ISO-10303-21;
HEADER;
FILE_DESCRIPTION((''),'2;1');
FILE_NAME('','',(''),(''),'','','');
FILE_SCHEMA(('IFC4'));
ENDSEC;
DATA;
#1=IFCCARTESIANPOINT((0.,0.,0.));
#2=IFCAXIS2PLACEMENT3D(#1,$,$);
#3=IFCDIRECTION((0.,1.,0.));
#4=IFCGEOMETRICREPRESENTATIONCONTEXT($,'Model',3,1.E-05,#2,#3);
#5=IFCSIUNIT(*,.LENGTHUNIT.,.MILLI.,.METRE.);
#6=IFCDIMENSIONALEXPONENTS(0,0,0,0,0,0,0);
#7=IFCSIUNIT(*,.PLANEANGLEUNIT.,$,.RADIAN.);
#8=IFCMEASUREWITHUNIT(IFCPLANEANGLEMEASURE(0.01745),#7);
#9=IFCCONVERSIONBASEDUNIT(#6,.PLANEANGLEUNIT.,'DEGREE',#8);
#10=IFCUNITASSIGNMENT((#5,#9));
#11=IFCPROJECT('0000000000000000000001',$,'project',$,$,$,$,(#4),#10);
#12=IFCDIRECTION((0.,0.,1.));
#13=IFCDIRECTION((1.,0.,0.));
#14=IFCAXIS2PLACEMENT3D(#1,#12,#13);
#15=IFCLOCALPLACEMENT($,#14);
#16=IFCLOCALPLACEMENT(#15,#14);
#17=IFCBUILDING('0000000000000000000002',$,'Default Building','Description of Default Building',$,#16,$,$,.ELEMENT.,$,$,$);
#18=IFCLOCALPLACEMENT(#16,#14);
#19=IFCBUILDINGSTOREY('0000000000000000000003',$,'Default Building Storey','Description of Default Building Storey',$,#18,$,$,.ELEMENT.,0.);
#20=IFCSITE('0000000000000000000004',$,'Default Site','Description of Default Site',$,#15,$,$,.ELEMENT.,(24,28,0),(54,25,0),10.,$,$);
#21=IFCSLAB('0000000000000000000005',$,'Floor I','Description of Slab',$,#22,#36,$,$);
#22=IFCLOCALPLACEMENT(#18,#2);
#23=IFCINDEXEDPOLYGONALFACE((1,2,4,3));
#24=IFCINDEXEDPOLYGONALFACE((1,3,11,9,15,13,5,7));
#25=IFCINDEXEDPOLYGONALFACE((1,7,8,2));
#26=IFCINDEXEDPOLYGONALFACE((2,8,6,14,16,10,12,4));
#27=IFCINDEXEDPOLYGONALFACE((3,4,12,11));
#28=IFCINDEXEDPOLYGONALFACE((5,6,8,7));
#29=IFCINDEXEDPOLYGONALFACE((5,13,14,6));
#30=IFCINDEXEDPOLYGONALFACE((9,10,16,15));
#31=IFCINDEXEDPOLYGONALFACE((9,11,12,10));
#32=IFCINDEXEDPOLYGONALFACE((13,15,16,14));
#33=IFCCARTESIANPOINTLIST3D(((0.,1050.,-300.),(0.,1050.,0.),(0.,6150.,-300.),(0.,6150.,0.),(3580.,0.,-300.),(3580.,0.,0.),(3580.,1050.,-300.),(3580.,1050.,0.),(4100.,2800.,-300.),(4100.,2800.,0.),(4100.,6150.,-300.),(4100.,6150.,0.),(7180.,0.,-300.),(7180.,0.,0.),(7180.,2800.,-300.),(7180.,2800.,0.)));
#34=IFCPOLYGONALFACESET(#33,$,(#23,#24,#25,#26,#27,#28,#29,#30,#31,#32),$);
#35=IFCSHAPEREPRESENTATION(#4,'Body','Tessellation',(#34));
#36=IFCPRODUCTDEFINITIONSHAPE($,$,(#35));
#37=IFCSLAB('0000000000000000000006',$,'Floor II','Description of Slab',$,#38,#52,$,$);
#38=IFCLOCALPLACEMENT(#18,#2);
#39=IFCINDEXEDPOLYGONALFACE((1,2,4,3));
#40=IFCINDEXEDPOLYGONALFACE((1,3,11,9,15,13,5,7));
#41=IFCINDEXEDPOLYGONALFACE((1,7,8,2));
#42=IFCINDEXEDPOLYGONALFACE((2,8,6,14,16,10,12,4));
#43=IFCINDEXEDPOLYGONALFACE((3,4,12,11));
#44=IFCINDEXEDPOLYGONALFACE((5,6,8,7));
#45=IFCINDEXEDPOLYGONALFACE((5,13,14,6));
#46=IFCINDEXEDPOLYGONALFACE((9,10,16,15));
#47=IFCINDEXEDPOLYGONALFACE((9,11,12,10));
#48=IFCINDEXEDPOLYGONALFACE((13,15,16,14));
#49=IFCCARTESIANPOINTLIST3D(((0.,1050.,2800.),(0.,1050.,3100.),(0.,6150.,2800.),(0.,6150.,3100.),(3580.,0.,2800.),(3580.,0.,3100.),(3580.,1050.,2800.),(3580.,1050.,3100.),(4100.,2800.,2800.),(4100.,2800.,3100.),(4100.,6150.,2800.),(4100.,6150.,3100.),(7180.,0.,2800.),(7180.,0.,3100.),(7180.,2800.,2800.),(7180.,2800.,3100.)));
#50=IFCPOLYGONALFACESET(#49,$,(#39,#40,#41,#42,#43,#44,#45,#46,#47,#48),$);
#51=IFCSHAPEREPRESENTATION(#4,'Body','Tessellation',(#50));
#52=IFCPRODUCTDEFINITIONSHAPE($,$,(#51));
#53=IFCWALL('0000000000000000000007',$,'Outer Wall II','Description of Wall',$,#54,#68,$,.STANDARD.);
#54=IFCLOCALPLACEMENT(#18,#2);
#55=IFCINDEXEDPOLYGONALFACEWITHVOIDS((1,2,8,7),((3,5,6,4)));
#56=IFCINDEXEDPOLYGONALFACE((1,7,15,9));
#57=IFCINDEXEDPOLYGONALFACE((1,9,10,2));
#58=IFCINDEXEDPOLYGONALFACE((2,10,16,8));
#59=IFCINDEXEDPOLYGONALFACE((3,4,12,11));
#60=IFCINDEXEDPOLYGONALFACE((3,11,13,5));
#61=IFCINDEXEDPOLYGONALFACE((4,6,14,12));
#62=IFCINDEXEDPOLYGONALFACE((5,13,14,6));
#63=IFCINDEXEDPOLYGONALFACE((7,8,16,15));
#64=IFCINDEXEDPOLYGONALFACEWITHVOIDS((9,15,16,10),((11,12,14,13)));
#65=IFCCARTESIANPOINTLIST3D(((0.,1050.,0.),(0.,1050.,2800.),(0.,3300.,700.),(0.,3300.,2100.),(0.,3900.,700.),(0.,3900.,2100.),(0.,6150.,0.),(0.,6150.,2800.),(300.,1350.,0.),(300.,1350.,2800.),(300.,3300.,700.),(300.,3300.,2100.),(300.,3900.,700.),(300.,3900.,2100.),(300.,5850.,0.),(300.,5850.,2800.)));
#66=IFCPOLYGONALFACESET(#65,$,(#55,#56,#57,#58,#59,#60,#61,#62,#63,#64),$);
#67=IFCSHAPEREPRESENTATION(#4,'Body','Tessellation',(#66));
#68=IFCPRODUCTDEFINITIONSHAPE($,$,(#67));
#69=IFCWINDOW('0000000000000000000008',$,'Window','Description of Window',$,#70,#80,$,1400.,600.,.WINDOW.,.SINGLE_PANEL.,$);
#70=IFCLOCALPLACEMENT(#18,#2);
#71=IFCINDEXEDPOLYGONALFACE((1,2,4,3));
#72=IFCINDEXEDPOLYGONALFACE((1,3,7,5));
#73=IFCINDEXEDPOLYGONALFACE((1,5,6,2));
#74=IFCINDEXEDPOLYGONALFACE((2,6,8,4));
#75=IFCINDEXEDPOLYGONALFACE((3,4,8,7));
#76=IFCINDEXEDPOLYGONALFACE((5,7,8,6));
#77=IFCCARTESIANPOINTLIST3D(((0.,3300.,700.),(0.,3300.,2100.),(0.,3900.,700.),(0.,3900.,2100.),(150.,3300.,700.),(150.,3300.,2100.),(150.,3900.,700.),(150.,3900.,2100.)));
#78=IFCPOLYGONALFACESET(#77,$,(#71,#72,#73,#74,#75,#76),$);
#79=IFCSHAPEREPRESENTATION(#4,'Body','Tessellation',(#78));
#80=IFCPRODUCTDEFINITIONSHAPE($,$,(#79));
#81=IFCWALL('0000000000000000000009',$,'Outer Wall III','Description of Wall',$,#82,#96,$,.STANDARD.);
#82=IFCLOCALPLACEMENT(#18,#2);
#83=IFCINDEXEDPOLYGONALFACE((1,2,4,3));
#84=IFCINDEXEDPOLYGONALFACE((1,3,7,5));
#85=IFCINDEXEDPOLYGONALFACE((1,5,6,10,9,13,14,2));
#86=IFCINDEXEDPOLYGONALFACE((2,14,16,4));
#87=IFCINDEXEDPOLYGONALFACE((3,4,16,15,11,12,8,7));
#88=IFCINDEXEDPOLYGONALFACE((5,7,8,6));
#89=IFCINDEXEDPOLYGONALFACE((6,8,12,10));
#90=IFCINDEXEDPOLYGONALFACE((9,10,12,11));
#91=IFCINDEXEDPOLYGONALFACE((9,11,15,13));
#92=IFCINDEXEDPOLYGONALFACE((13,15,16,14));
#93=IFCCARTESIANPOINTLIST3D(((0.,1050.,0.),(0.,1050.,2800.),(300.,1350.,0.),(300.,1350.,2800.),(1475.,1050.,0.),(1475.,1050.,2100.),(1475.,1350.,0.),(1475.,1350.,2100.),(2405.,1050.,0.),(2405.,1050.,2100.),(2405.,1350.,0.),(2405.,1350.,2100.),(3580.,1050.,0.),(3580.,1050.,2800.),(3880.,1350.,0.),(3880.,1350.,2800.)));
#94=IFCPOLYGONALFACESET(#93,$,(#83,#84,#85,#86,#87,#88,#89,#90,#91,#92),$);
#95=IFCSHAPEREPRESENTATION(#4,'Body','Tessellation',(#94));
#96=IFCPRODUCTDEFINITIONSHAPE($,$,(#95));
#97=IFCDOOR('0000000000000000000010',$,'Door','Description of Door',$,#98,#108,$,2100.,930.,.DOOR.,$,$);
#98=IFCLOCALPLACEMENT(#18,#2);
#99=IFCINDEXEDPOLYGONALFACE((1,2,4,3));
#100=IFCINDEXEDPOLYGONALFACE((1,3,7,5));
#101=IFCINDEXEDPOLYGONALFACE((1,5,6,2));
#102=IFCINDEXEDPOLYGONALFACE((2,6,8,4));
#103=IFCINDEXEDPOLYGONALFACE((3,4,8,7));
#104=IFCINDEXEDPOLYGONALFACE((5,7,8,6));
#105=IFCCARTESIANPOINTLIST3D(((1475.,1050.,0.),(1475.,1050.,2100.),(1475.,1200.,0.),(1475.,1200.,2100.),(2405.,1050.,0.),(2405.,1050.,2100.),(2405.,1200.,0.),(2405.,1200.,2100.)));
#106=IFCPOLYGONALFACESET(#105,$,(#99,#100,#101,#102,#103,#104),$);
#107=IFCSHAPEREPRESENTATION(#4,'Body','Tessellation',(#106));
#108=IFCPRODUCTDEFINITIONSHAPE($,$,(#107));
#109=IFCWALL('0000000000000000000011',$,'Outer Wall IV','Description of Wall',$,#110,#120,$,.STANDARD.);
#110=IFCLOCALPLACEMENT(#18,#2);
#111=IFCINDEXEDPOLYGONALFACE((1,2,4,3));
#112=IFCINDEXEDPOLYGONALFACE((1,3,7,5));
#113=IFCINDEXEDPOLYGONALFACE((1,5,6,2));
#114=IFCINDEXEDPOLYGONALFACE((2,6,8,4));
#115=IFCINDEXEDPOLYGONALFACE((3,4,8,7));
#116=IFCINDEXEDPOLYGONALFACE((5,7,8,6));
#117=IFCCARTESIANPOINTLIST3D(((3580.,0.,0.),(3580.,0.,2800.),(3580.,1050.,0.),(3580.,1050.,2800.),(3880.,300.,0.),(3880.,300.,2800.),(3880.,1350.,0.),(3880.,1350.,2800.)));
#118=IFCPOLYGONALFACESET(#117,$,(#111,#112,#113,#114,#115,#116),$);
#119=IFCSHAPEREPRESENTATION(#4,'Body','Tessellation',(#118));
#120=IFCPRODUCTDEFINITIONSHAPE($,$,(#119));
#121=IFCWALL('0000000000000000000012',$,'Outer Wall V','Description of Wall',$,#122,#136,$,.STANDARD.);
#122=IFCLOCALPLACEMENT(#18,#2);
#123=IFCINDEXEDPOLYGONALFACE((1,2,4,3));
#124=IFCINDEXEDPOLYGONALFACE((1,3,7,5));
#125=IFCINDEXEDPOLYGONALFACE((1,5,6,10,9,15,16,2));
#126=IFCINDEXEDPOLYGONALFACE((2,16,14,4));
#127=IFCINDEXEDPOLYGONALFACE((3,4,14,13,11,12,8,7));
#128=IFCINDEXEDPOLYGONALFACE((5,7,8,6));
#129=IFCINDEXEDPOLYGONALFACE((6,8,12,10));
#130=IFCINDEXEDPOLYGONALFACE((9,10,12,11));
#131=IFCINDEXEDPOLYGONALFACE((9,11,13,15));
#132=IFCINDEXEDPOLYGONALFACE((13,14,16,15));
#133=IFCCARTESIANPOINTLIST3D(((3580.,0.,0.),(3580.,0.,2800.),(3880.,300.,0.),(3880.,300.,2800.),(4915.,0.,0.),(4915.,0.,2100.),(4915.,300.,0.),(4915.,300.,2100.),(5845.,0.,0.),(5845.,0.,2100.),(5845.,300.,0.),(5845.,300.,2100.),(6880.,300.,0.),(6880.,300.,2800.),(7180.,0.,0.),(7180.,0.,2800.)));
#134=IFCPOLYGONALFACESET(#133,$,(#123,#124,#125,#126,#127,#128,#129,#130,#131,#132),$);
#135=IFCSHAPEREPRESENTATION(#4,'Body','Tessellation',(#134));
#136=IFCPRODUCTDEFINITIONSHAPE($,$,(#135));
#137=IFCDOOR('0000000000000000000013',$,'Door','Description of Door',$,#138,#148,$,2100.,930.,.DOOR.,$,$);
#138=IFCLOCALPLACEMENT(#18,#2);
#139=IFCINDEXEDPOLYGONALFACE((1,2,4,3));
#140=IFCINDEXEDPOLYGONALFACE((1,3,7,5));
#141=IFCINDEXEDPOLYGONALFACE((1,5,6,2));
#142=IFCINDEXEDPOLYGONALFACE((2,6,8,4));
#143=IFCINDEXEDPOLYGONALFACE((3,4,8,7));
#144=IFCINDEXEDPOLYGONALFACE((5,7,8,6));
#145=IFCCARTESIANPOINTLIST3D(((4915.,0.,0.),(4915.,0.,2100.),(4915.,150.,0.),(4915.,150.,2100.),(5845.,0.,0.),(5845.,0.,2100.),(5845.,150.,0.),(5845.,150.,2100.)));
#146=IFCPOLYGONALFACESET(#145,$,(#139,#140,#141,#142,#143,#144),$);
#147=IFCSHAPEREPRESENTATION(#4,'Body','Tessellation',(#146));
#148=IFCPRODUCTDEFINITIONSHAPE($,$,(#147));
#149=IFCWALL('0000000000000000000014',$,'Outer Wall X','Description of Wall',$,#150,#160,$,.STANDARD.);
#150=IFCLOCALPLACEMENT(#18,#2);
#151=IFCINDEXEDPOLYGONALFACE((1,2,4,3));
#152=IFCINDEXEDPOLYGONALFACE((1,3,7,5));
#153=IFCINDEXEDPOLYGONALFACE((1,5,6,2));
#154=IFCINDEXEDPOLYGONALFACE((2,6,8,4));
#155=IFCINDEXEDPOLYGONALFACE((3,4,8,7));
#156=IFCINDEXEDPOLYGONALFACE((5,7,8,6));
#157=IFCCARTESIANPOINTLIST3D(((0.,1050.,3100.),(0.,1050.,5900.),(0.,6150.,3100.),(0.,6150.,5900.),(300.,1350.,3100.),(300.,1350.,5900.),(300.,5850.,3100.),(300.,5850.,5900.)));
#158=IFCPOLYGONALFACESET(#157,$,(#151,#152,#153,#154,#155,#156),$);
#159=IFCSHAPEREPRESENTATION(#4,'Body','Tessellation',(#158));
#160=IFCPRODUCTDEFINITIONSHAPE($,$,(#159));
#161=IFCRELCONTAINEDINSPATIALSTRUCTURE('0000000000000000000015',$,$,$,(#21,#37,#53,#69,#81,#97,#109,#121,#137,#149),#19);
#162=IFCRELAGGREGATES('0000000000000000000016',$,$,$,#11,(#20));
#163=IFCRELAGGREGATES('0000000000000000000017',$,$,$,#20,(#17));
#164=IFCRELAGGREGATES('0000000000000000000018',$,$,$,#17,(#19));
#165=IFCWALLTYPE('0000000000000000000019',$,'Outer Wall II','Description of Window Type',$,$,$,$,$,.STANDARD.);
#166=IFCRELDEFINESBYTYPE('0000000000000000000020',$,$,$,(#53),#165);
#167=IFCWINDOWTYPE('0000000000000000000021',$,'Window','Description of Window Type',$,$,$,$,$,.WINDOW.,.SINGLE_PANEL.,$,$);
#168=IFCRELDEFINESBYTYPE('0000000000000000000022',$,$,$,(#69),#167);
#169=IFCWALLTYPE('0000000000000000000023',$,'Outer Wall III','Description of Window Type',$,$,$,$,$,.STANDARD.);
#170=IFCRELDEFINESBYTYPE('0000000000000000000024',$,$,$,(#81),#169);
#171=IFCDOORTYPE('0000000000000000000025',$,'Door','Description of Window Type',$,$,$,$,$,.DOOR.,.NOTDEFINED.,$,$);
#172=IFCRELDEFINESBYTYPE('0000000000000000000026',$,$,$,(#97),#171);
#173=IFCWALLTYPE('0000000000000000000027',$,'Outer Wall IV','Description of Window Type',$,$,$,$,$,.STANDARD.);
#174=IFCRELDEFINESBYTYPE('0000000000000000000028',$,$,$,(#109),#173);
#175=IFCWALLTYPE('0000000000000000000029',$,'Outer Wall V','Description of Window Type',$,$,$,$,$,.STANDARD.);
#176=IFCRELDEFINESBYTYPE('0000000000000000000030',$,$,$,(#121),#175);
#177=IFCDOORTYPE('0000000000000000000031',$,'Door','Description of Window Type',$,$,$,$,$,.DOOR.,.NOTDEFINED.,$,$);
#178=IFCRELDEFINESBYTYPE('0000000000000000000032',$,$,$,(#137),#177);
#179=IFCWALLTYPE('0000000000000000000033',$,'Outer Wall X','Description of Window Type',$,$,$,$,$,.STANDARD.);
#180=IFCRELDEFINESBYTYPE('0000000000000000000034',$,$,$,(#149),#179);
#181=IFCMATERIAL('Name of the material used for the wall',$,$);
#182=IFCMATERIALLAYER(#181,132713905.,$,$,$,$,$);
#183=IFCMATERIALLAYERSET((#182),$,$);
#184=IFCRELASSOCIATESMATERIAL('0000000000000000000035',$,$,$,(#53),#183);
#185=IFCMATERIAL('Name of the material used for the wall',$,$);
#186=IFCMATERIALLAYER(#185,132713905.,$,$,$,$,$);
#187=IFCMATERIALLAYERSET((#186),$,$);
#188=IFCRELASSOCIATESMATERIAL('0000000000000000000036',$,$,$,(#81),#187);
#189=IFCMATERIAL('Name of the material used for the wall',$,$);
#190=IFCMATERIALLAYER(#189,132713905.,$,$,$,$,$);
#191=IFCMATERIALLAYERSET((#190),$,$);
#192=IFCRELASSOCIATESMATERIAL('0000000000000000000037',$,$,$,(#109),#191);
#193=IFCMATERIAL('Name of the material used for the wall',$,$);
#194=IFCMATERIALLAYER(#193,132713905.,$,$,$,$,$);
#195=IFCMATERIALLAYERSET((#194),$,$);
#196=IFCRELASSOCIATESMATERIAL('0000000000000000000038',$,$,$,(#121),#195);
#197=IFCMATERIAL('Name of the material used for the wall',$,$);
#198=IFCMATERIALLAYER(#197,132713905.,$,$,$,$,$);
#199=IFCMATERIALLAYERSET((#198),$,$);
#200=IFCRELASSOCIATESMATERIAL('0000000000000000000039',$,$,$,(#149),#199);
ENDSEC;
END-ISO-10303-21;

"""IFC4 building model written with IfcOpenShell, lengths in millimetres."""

from ifc_helpers import new_model, entity, si_unit, converted_unit, direction, frame, origin, origin_with_axes, place, context, project, spatial, polyline, outline, extrude, material, layer, layer_set, layer_usage, type_object, element, fill, save


model = new_model("IFC4")

# Units and contexts
model_context = context("Model", 3, precision=1e-05, world=origin(), true_north=direction((0.0, 1.0, 0.0)))
ifc_project = project(units=[si_unit("LENGTHUNIT", "METRE", prefix="MILLI"), converted_unit("PLANEANGLEUNIT", "DEGREE", entity("IfcPlaneAngleMeasure", 0.01745), si_unit("PLANEANGLEUNIT", "RADIAN"), dimensions=[0, 0, 0, 0, 0, 0, 0])], contexts=[model_context])

# Site, building, storey
site_placement = place(None, origin_with_axes())
site = spatial("IfcSite", under=ifc_project, at=site_placement, Name="Default Site", Description="Description of Default Site", CompositionType="ELEMENT", RefLatitude=(24, 28, 0), RefLongitude=(54, 25, 0), RefElevation=10.0)
building_placement = place(site_placement, origin_with_axes())
building = spatial("IfcBuilding", under=site, at=building_placement, Name="Default Building", Description="Description of Default Building", CompositionType="ELEMENT")
storey_placement = place(building_placement, origin_with_axes())
storey = spatial("IfcBuildingStorey", under=building, at=storey_placement, Name="Default Building Storey", Description="Description of Default Building Storey", CompositionType="ELEMENT", Elevation=0.0)

# Slabs
for number, where, z_axis, x_axis, name in (
    (1, (0.0, 0.0, -300.0), (0.0, 0.0, 1.0), (1.0, 0.0, 0.0), "Floor I"),
    (2, (0.0, 0.0, 2800.0), (0.0, 0.0, 1.0), (1.0, 0.0, 0.0), "Floor II"),
):
    element("IfcSlab", number, at=place(storey_placement, frame(where, z_axis=z_axis, x_axis=x_axis)), inside=storey, Name=name, Description="Description of Slab", context=model_context, shape_type="SweptSolid", body=[
        extrude(outline(polyline([(0.0, 1050.0), (0.0, 6150.0), (4100.0, 6150.0), (4100.0, 2800.0), (7180.0, 2800.0), (7180.0, 0.0), (3580.0, 0.0), (3580.0, 1050.0), (0.0, 1050.0)])), origin_with_axes(), (0.0, 0.0, 1.0), 300.0),
    ])

# Wall, opening, window
ifc_material_1 = material(Name="Name of the material used for the wall")
ifc_layer_1 = layer(ifc_material_1, 132713905.0)
ifc_layer_set_1 = layer_set([ifc_layer_1])
ifc_layer_usage_1 = layer_usage(ifc_layer_set_1, "AXIS2", "POSITIVE", -66356952.5)
wall_type_1 = type_object("IfcWallType", Name="Outer Wall II", Description="Description of Window Type", PredefinedType="STANDARD")
wall_1_placement = place(storey_placement, frame((150.0, 6000.0, 0.0), z_axis=(0.0, 0.0, 1.0), x_axis=(0.0, -1.0, 0.0)))
wall_1 = element("IfcWall", 3, at=wall_1_placement, inside=storey, type_object=wall_type_1, material=ifc_layer_usage_1, Name="Outer Wall II", Description="Description of Wall", PredefinedType="STANDARD", context=model_context, shape_type="SweptSolid", body=[
    extrude(outline(polyline([(-150.0, -150.0), (150.0, 150.0), (4650.0, 150.0), (4950.0, -150.0), (-150.0, -150.0)])), origin_with_axes(), (0.0, 0.0, 1.0), 2800.0),
])
opening_1_placement = place(wall_1_placement, frame((2100.0, -150.0, 700.0), z_axis=(0.0, 0.0, 1.0), x_axis=(1.0, 0.0, 0.0)))
opening_1 = element("IfcOpeningElement", 4, at=opening_1_placement, cuts=wall_1, context=model_context, shape_type="SweptSolid", body=[
    extrude(outline(polyline([(0.0, 0.0), (0.0, 300.0), (600.0, 300.0), (600.0, 0.0), (0.0, 0.0)])), origin_with_axes(), (0.0, 0.0, 1.0), 1400.0),
])
window_type_1 = type_object("IfcWindowType", Name="Window", Description="Description of Window Type", PartitioningType="SINGLE_PANEL", PredefinedType="WINDOW")
window_1_placement = place(opening_1_placement, origin_with_axes())
window_1 = element("IfcWindow", 5, at=window_1_placement, inside=storey, type_object=window_type_1, Name="Window", Description="Description of Window", OverallHeight=1400.0, OverallWidth=600.0, PartitioningType="SINGLE_PANEL", PredefinedType="WINDOW", context=model_context, shape_type="SweptSolid", body=[
    extrude(outline(polyline([(0.0, 0.0), (0.0, 150.0), (600.0, 150.0), (600.0, 0.0), (0.0, 0.0)])), origin_with_axes(), (0.0, 0.0, 1.0), 1400.0),
])
fill(opening_1, window_1)

# Wall, opening, door
ifc_material_2 = material(Name="Name of the material used for the wall")
ifc_layer_2 = layer(ifc_material_2, 132713905.0)
ifc_layer_set_2 = layer_set([ifc_layer_2])
ifc_layer_usage_2 = layer_usage(ifc_layer_set_2, "AXIS2", "POSITIVE", -66356952.5)
wall_type_2 = type_object("IfcWallType", Name="Outer Wall III", Description="Description of Window Type", PredefinedType="STANDARD")
wall_2_placement = place(storey_placement, frame((150.0, 1200.0, 0.0), z_axis=(0.0, 0.0, 1.0), x_axis=(1.0, 0.0, 0.0)))
wall_2 = element("IfcWall", 6, at=wall_2_placement, inside=storey, type_object=wall_type_2, material=ifc_layer_usage_2, Name="Outer Wall III", Description="Description of Wall", PredefinedType="STANDARD", context=model_context, shape_type="SweptSolid", body=[
    extrude(outline(polyline([(-150.0, -150.0), (150.0, 150.0), (3730.0, 150.0), (3430.0, -150.0), (-150.0, -150.0)])), origin_with_axes(), (0.0, 0.0, 1.0), 2800.0),
])
opening_2_placement = place(wall_2_placement, frame((1325.0, -150.0, 0.0), z_axis=(0.0, 0.0, 1.0), x_axis=(1.0, 0.0, 0.0)))
opening_2 = element("IfcOpeningElement", 7, at=opening_2_placement, cuts=wall_2, context=model_context, shape_type="SweptSolid", body=[
    extrude(outline(polyline([(0.0, 0.0), (0.0, 300.0), (930.0, 300.0), (930.0, 0.0), (0.0, 0.0)])), origin_with_axes(), (0.0, 0.0, 1.0), 2100.0),
])
door_type_1 = type_object("IfcDoorType", Name="Door", Description="Description of Window Type", PredefinedType="DOOR")
door_1_placement = place(opening_2_placement, origin_with_axes())
door_1 = element("IfcDoor", 8, at=door_1_placement, inside=storey, type_object=door_type_1, Name="Door", Description="Description of Door", OverallHeight=2100.0, OverallWidth=930.0, PredefinedType="DOOR", context=model_context, shape_type="SweptSolid", body=[
    extrude(outline(polyline([(0.0, 0.0), (0.0, 150.0), (930.0, 150.0), (930.0, 0.0), (0.0, 0.0)])), origin_with_axes(), (0.0, 0.0, 1.0), 2100.0),
])
fill(opening_2, door_1)

# Wall
ifc_material_3 = material(Name="Name of the material used for the wall")
ifc_layer_3 = layer(ifc_material_3, 132713905.0)
ifc_layer_set_3 = layer_set([ifc_layer_3])
ifc_layer_usage_3 = layer_usage(ifc_layer_set_3, "AXIS2", "POSITIVE", -66356952.5)
wall_type_3 = type_object("IfcWallType", Name="Outer Wall IV", Description="Description of Window Type", PredefinedType="STANDARD")
wall_3_placement = place(storey_placement, frame((3730.0, 1200.0, 0.0), z_axis=(0.0, 0.0, 1.0), x_axis=(0.0, -1.0, 0.0)))
element("IfcWall", 9, at=wall_3_placement, inside=storey, type_object=wall_type_3, material=ifc_layer_usage_3, Name="Outer Wall IV", Description="Description of Wall", PredefinedType="STANDARD", context=model_context, shape_type="SweptSolid", body=[
    extrude(outline(polyline([(150.0, -150.0), (-150.0, 150.0), (900.0, 150.0), (1200.0, -150.0), (150.0, -150.0)])), origin_with_axes(), (0.0, 0.0, 1.0), 2800.0),
])

# Wall, opening, door
ifc_material_4 = material(Name="Name of the material used for the wall")
ifc_layer_4 = layer(ifc_material_4, 132713905.0)
ifc_layer_set_4 = layer_set([ifc_layer_4])
ifc_layer_usage_4 = layer_usage(ifc_layer_set_4, "AXIS2", "POSITIVE", -66356952.5)
wall_type_4 = type_object("IfcWallType", Name="Outer Wall V", Description="Description of Window Type", PredefinedType="STANDARD")
wall_4_placement = place(storey_placement, frame((3730.0, 150.0, 0.0), z_axis=(0.0, 0.0, 1.0), x_axis=(1.0, 0.0, 0.0)))
wall_4 = element("IfcWall", 10, at=wall_4_placement, inside=storey, type_object=wall_type_4, material=ifc_layer_usage_4, Name="Outer Wall V", Description="Description of Wall", PredefinedType="STANDARD", context=model_context, shape_type="SweptSolid", body=[
    extrude(outline(polyline([(-150.0, -150.0), (150.0, 150.0), (3150.0, 150.0), (3450.0, -150.0), (-150.0, -150.0)])), origin_with_axes(), (0.0, 0.0, 1.0), 2800.0),
])
opening_3_placement = place(wall_4_placement, frame((1185.0, -150.0, 0.0), z_axis=(0.0, 0.0, 1.0), x_axis=(1.0, 0.0, 0.0)))
opening_3 = element("IfcOpeningElement", 11, at=opening_3_placement, cuts=wall_4, context=model_context, shape_type="SweptSolid", body=[
    extrude(outline(polyline([(0.0, 0.0), (0.0, 300.0), (930.0, 300.0), (930.0, 0.0), (0.0, 0.0)])), origin_with_axes(), (0.0, 0.0, 1.0), 2100.0),
])
door_type_2 = type_object("IfcDoorType", Name="Door", Description="Description of Window Type", PredefinedType="DOOR")
door_2_placement = place(opening_3_placement, origin_with_axes())
door_2 = element("IfcDoor", 12, at=door_2_placement, inside=storey, type_object=door_type_2, Name="Door", Description="Description of Door", OverallHeight=2100.0, OverallWidth=930.0, PredefinedType="DOOR", context=model_context, shape_type="SweptSolid", body=[
    extrude(outline(polyline([(0.0, 0.0), (0.0, 150.0), (930.0, 150.0), (930.0, 0.0), (0.0, 0.0)])), origin_with_axes(), (0.0, 0.0, 1.0), 2100.0),
])
fill(opening_3, door_2)

# Wall
ifc_material_5 = material(Name="Name of the material used for the wall")
ifc_layer_5 = layer(ifc_material_5, 132713905.0)
ifc_layer_set_5 = layer_set([ifc_layer_5])
ifc_layer_usage_5 = layer_usage(ifc_layer_set_5, "AXIS2", "POSITIVE", -66356952.5)
wall_type_5 = type_object("IfcWallType", Name="Outer Wall X", Description="Description of Window Type", PredefinedType="STANDARD")
wall_5_placement = place(storey_placement, frame((150.0, 6000.0, 3100.0), z_axis=(0.0, 0.0, 1.0), x_axis=(0.0, -1.0, 0.0)))
element("IfcWall", 13, at=wall_5_placement, inside=storey, type_object=wall_type_5, material=ifc_layer_usage_5, Name="Outer Wall X", Description="Description of Wall", PredefinedType="STANDARD", context=model_context, shape_type="SweptSolid", body=[
    extrude(outline(polyline([(-150.0, -150.0), (150.0, 150.0), (4650.0, 150.0), (4950.0, -150.0), (-150.0, -150.0)])), origin_with_axes(), (0.0, 0.0, 1.0), 2800.0),
])

save(model, "model.ifc")
